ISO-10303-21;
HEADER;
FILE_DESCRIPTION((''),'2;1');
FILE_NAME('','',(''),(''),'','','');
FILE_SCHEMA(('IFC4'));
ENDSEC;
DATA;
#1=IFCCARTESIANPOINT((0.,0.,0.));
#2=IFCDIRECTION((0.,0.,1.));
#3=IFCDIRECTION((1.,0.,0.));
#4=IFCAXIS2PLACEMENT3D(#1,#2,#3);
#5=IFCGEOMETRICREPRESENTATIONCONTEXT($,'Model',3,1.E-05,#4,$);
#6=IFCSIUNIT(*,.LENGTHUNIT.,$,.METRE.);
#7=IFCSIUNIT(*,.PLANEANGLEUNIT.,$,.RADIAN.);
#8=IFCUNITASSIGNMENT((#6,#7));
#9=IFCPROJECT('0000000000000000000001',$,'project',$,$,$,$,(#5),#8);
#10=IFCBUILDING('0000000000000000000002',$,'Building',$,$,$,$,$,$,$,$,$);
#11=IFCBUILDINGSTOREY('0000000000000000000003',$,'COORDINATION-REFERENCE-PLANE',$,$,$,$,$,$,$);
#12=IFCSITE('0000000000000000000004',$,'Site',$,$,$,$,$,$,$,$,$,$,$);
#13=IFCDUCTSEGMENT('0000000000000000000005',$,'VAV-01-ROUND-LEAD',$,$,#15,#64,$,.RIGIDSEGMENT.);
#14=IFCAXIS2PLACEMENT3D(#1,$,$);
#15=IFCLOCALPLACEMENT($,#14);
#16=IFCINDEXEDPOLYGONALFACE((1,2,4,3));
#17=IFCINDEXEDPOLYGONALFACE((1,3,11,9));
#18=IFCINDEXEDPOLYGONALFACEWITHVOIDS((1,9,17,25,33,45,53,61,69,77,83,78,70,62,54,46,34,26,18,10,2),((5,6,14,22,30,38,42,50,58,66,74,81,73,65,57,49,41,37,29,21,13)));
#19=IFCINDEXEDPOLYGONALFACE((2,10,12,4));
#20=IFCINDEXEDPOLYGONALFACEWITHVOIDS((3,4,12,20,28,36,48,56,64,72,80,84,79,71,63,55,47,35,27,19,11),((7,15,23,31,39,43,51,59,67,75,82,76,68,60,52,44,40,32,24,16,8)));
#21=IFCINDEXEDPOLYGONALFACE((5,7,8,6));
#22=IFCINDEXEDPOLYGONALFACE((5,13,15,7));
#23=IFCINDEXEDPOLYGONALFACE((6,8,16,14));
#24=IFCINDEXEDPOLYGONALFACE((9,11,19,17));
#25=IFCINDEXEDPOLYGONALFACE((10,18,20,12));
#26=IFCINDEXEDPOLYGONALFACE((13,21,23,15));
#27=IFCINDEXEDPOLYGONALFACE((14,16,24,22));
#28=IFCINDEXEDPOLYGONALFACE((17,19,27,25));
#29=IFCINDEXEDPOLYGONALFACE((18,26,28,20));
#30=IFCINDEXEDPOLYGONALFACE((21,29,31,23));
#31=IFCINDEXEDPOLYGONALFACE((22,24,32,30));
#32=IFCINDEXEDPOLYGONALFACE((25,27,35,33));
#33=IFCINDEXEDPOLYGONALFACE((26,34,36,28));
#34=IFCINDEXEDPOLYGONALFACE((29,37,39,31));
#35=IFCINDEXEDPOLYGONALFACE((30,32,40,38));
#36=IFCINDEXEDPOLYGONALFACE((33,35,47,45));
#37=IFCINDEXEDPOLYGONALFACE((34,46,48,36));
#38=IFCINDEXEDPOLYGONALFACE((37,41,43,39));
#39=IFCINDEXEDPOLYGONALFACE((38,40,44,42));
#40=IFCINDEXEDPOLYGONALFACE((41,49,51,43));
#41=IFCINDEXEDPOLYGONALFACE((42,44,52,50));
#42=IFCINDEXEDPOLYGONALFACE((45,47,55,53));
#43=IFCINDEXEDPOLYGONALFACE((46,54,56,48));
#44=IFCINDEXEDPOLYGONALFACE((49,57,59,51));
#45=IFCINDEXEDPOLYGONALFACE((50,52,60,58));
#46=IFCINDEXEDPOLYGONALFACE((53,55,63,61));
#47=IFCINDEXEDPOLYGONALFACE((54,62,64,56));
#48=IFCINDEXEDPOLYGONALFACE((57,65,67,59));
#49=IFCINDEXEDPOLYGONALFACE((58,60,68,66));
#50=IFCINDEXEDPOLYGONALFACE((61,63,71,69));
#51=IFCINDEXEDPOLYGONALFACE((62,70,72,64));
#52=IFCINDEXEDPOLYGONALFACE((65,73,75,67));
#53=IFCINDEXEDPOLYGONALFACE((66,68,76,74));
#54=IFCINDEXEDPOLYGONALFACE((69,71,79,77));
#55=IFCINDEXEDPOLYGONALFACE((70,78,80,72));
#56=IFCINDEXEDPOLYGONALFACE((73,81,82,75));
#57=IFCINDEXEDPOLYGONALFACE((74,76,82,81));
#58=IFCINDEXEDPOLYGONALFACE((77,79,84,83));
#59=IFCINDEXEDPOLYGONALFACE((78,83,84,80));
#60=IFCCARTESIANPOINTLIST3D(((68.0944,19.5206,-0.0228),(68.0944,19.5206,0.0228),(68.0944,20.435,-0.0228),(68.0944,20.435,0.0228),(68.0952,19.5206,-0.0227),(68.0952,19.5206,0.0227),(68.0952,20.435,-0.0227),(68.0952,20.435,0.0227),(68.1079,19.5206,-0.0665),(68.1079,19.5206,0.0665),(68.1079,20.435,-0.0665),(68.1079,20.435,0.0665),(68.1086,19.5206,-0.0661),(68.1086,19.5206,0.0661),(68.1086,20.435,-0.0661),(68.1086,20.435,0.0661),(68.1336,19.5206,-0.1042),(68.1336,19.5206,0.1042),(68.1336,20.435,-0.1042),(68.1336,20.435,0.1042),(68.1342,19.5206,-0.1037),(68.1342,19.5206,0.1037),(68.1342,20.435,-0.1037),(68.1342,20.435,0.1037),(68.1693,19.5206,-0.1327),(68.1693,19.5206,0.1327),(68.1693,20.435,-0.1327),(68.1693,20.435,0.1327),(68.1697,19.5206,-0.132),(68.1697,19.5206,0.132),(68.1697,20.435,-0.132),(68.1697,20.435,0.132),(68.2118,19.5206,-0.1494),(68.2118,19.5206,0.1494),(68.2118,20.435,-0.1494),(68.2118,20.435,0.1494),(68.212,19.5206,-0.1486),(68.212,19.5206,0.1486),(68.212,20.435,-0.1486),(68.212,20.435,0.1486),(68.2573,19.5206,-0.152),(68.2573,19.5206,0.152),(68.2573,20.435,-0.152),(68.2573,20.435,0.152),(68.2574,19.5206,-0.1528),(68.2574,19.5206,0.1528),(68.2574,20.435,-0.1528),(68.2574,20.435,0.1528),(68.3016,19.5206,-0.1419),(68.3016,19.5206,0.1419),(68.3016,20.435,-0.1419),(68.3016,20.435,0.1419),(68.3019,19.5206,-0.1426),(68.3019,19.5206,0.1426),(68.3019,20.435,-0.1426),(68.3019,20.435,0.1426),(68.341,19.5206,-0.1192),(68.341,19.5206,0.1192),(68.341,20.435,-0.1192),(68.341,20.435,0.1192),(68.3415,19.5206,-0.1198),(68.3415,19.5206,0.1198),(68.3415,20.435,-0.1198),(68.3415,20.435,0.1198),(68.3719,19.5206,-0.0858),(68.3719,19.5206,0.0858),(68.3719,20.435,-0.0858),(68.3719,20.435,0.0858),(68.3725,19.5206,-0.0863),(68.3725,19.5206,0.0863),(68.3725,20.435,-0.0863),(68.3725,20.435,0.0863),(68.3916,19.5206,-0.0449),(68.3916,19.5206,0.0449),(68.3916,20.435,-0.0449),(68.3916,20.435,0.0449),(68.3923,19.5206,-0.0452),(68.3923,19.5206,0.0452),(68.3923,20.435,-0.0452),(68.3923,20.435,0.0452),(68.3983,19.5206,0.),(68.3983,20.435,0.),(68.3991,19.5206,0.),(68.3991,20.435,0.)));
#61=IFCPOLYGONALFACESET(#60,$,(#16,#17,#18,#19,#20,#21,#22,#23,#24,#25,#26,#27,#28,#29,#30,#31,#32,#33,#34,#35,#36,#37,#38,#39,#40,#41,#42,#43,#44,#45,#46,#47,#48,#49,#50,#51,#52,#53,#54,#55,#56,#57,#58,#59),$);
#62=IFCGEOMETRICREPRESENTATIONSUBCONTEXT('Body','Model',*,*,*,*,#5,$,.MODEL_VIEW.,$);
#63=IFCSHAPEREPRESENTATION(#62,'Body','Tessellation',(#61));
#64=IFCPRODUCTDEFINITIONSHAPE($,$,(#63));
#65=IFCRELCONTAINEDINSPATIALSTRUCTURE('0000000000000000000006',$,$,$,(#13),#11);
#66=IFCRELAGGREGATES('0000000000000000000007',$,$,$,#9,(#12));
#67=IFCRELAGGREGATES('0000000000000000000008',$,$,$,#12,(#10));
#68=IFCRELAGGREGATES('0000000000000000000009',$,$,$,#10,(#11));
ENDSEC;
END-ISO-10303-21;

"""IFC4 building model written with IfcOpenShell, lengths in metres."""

from ifc_helpers import new_model, si_unit, frame, origin, origin_with_axes, place, context, subcontext, project, spatial, hollow_circle, extrude, element, save


model = new_model("IFC4")

# Units and contexts
model_context = context("Model", 3, precision=1e-05, world=origin_with_axes())
body_context_1 = subcontext(model_context, "Body", "Model", "MODEL_VIEW")
ifc_project = project(units=[si_unit("LENGTHUNIT", "METRE"), si_unit("PLANEANGLEUNIT", "RADIAN")], contexts=[model_context])

# Site, building, storey
site = spatial("IfcSite", under=ifc_project, Name="Site")
building = spatial("IfcBuilding", under=site, Name="Building")
storey = spatial("IfcBuildingStorey", under=building, Name="COORDINATION-REFERENCE-PLANE")

# Duct segment
duct_segment_1_placement = place(None, frame((68.2459, 20.435, 0.0), z_axis=(0.0, -1.0, 0.0), x_axis=(1.0, 0.0, 0.0)))
element("IfcDuctSegment", 1, at=duct_segment_1_placement, inside=storey, Name="VAV-01-ROUND-LEAD", PredefinedType="RIGIDSEGMENT", context=body_context_1, shape_type="SweptSolid", body=[
    extrude(hollow_circle(Radius=0.1532, WallThickness=0.0008), origin(), (0.0, 0.0, 1.0), 0.9144),
])

save(model, "model.ifc")
